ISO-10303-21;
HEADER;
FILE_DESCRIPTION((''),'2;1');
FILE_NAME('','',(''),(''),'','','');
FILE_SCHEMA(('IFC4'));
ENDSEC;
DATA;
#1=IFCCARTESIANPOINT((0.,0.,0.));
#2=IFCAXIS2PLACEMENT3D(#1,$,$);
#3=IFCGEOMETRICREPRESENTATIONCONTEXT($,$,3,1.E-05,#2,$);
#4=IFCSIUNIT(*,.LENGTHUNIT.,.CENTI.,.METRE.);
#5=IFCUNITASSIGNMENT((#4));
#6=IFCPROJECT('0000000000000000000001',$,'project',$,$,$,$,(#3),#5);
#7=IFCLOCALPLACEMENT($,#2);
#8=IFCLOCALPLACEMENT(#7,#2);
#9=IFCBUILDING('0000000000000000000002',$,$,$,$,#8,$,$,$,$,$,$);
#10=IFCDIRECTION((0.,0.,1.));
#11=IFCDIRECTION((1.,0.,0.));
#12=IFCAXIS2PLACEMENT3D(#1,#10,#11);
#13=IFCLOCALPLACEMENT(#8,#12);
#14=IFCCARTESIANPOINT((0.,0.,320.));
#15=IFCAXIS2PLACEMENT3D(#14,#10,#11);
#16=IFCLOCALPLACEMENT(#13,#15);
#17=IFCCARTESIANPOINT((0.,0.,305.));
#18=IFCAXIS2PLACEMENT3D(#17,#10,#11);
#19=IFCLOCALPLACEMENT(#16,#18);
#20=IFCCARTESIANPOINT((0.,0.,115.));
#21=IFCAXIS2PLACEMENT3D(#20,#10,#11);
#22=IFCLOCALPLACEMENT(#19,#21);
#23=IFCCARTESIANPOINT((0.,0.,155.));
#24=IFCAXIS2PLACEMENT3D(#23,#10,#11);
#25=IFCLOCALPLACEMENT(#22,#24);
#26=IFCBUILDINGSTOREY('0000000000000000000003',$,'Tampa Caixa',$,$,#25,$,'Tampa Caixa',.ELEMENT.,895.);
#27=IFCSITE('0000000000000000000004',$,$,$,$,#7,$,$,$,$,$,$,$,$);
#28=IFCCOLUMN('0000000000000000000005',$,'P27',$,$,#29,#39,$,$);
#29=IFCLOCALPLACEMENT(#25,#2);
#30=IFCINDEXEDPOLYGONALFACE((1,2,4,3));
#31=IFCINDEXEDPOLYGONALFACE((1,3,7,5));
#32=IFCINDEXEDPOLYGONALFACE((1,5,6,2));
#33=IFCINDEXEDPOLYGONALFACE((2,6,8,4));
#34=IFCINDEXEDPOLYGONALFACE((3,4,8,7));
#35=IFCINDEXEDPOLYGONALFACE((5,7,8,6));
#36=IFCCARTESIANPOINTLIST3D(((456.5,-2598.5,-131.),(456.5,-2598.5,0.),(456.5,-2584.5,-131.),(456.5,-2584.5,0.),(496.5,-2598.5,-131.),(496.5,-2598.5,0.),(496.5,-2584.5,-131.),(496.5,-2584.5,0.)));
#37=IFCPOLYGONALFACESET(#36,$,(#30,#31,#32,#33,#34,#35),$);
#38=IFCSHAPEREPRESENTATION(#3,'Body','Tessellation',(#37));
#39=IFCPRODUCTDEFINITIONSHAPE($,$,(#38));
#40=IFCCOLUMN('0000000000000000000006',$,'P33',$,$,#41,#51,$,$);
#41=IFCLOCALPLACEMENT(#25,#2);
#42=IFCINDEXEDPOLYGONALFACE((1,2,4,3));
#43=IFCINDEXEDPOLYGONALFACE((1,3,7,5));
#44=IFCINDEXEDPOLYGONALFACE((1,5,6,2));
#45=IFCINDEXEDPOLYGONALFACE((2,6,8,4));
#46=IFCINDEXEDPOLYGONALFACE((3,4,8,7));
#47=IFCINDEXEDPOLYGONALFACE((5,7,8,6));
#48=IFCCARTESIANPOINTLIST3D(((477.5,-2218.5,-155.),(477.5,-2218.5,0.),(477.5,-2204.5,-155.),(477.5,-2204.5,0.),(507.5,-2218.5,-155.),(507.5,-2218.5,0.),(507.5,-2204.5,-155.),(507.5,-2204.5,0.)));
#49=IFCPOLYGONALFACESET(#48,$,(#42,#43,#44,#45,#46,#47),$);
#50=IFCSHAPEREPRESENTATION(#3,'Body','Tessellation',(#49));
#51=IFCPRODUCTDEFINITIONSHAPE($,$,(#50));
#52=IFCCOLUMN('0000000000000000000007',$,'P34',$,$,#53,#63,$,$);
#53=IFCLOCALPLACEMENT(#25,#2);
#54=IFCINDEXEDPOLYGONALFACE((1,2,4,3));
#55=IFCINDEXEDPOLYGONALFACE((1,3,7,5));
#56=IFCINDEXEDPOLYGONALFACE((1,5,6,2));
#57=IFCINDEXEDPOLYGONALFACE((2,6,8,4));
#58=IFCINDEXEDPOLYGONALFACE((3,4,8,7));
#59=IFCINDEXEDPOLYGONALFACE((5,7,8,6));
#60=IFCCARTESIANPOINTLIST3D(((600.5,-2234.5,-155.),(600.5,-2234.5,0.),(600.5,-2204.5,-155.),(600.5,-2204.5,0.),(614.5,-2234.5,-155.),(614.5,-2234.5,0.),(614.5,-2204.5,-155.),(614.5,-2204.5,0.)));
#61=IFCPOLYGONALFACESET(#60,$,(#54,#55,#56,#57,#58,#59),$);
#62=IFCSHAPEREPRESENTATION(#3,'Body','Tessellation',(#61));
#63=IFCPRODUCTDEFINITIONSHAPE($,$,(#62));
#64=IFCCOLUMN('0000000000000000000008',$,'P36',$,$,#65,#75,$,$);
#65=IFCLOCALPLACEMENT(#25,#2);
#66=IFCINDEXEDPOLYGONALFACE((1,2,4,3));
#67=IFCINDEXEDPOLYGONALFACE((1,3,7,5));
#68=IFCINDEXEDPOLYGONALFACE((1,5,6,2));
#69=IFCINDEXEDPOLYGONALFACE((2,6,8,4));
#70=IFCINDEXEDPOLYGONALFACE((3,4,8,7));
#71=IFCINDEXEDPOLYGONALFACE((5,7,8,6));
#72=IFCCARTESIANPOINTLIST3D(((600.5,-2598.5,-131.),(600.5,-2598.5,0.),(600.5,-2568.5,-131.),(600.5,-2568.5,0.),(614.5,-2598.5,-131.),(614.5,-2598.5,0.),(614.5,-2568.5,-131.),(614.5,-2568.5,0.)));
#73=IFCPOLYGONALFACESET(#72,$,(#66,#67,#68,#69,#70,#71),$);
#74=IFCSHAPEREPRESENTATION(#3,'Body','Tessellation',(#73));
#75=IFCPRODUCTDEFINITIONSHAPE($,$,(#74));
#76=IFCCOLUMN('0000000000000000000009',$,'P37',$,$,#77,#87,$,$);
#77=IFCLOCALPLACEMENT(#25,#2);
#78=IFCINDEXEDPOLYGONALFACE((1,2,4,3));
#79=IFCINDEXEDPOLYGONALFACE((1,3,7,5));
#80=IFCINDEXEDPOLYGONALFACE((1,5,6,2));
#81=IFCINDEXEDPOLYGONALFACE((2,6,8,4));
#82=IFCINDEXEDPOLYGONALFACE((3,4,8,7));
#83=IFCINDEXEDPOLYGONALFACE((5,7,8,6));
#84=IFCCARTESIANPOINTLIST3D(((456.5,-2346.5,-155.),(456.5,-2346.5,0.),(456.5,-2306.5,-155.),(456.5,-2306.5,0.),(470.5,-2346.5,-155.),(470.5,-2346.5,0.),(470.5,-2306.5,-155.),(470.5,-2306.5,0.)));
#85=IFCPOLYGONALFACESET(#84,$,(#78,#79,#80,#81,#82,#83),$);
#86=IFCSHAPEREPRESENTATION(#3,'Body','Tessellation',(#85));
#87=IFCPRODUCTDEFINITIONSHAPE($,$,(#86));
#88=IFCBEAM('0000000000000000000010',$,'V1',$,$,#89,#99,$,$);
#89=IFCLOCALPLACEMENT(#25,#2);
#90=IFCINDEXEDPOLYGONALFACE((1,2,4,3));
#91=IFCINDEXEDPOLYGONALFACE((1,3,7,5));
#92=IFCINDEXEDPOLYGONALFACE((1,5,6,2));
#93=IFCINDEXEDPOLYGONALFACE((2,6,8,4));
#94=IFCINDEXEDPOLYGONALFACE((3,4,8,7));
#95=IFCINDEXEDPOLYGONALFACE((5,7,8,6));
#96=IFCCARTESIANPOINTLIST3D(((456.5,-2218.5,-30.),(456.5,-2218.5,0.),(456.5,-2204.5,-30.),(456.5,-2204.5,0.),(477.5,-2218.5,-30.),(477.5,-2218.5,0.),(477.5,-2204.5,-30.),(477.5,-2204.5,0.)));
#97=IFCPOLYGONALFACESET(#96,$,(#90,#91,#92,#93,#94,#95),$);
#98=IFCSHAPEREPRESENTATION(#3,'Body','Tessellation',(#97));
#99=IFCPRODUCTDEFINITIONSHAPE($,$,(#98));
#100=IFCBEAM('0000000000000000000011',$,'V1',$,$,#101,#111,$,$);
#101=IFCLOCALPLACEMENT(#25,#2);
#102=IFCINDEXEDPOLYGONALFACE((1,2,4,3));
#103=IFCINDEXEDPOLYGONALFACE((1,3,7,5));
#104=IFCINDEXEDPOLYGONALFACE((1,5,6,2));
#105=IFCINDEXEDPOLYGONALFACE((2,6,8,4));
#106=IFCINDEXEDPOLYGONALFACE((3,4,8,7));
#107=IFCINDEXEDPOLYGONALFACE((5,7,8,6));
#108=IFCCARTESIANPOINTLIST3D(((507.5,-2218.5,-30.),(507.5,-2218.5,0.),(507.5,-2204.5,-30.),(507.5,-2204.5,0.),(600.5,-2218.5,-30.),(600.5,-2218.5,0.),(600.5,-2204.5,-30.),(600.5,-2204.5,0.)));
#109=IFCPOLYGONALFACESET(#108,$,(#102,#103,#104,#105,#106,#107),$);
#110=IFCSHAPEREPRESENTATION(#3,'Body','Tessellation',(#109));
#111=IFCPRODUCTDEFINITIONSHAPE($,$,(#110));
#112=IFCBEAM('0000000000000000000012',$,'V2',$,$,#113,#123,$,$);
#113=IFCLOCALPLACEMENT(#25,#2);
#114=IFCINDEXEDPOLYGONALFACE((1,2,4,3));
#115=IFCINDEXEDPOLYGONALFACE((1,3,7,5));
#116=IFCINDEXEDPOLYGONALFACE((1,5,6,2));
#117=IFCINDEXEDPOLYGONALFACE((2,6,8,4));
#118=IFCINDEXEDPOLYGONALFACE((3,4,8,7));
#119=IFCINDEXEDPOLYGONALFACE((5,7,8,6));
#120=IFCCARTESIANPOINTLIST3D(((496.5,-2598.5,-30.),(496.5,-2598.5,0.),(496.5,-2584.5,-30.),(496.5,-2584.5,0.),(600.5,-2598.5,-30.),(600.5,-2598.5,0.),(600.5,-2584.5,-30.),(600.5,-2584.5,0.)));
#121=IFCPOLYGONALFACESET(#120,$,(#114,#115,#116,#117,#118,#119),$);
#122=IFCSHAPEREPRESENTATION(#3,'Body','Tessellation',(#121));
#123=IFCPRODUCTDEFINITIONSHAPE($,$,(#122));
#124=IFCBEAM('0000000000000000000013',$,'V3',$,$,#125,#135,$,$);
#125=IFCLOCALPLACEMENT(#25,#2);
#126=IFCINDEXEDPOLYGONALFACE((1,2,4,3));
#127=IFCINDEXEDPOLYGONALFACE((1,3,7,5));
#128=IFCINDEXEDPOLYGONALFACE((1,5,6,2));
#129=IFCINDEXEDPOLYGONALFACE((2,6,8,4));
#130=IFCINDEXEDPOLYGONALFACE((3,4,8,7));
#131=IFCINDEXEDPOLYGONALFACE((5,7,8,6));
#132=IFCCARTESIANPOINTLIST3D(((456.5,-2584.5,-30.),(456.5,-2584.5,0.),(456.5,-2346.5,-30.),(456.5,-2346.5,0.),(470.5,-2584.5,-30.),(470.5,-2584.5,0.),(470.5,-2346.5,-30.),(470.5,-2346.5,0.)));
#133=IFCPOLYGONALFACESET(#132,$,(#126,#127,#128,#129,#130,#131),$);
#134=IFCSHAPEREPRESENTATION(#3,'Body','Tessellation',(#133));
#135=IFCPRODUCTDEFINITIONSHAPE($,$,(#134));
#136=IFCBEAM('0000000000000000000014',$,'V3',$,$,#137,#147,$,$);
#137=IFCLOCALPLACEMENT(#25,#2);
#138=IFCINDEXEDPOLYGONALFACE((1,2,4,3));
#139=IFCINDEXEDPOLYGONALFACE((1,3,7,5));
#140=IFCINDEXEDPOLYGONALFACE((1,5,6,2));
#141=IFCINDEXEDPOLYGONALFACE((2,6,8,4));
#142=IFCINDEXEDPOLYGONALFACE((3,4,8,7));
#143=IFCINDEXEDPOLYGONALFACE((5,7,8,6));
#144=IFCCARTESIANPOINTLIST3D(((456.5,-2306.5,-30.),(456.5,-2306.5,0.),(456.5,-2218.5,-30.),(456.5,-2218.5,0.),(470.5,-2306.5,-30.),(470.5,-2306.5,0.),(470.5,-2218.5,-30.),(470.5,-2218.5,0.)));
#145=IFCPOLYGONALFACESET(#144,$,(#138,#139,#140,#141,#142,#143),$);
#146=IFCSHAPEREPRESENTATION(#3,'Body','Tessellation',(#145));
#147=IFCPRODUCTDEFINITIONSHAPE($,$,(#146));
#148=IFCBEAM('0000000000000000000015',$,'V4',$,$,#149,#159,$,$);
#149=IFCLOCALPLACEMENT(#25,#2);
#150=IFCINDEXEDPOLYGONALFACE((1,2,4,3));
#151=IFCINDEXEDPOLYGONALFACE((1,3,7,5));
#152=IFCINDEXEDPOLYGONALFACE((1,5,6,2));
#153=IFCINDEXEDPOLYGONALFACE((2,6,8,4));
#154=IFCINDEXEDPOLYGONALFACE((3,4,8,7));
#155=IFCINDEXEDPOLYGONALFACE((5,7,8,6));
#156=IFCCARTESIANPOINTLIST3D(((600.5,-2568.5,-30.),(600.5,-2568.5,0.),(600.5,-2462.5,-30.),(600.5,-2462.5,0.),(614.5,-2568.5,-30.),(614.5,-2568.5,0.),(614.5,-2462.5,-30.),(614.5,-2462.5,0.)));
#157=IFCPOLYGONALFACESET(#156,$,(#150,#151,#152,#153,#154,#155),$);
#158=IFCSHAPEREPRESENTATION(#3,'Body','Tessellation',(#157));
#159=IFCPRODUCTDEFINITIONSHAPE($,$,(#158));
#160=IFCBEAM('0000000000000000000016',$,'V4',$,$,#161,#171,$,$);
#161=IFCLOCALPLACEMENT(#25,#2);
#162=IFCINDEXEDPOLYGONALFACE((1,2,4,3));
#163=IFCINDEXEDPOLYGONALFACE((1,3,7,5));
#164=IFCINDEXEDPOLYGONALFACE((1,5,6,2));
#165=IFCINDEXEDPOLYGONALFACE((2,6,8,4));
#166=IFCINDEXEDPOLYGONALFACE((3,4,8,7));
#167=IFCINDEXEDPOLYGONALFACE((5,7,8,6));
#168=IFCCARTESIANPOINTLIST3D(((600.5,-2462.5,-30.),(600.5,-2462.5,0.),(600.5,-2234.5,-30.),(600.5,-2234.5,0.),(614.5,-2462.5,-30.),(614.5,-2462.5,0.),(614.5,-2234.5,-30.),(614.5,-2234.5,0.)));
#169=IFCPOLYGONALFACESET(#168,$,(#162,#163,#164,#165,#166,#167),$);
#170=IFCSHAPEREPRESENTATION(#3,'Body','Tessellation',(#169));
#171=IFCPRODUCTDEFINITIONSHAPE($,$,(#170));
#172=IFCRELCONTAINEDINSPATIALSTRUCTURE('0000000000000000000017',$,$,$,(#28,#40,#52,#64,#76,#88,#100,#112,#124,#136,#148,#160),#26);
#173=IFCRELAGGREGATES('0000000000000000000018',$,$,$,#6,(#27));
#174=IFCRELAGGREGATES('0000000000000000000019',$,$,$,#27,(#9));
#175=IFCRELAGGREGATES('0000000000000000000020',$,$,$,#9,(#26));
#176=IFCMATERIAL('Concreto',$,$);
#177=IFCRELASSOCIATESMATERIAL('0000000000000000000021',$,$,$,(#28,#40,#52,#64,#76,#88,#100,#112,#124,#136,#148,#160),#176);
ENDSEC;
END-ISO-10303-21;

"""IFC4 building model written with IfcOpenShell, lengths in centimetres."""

from ifc_helpers import new_model, si_unit, frame, origin, origin_with_axes, place, context, project, spatial, polyline, outline, extrude, material, element, save


model = new_model("IFC4")

# Units and contexts
context_of_model = context(None, 3, precision=1e-05, world=origin())
ifc_project = project(units=[si_unit("LENGTHUNIT", "METRE", prefix="CENTI")], contexts=[context_of_model])

# Site, building, storey
site_placement = place(None, origin())
site = spatial("IfcSite", under=ifc_project, at=site_placement)
building_placement = place(site_placement, origin())
building = spatial("IfcBuilding", under=site, at=building_placement)
placement_1 = place(building_placement, origin_with_axes())
placement_2 = place(placement_1, frame((0.0, 0.0, 320.0), z_axis=(0.0, 0.0, 1.0), x_axis=(1.0, 0.0, 0.0)))
placement_3 = place(placement_2, frame((0.0, 0.0, 305.0), z_axis=(0.0, 0.0, 1.0), x_axis=(1.0, 0.0, 0.0)))
placement_4 = place(placement_3, frame((0.0, 0.0, 115.0), z_axis=(0.0, 0.0, 1.0), x_axis=(1.0, 0.0, 0.0)))
storey_placement = place(placement_4, frame((0.0, 0.0, 155.0), z_axis=(0.0, 0.0, 1.0), x_axis=(1.0, 0.0, 0.0)))
storey = spatial("IfcBuildingStorey", under=building, at=storey_placement, Name="Tampa Caixa", LongName="Tampa Caixa", CompositionType="ELEMENT", Elevation=895.0)

# Columns
ifc_material = material(Name="Concreto")
column_1_placement = place(storey_placement, frame((476.5, -2591.5, 0.0), z_axis=(0.0, 0.0, 1.0), x_axis=(1.0, 0.0, 0.0)))
element("IfcColumn", 1, at=column_1_placement, inside=storey, material=ifc_material, Name="P27", context=context_of_model, shape_type="SolidModel", body=[
    extrude(outline(polyline([(20.0, -7.0), (20.0, 7.0), (-20.0, 7.0), (-20.0, -7.0), (20.0, -7.0)])), origin_with_axes(), (0.0, 0.0, -1.0), 131.0),
])
column_2_placement = place(storey_placement, frame((492.5, -2211.5, 0.0), z_axis=(0.0, 0.0, 1.0), x_axis=(1.0, 0.0, 0.0)))
element("IfcColumn", 2, at=column_2_placement, inside=storey, material=ifc_material, Name="P33", context=context_of_model, shape_type="SolidModel", body=[
    extrude(outline(polyline([(15.0, -7.0), (15.0, 7.0), (-15.0, 7.0), (-15.0, -7.0), (15.0, -7.0)])), origin_with_axes(), (0.0, 0.0, -1.0), 155.0),
])
column_3_placement = place(storey_placement, frame((607.5, -2219.5, 0.0), z_axis=(0.0, 0.0, 1.0), x_axis=(1.0, 0.0, 0.0)))
element("IfcColumn", 3, at=column_3_placement, inside=storey, material=ifc_material, Name="P34", context=context_of_model, shape_type="SolidModel", body=[
    extrude(outline(polyline([(7.0, 15.0), (-7.0, 15.0), (-7.0, -15.0), (7.0, -15.0), (7.0, 15.0)])), origin_with_axes(), (0.0, 0.0, -1.0), 155.0),
])
column_4_placement = place(storey_placement, frame((607.5, -2583.5, 0.0), z_axis=(0.0, 0.0, 1.0), x_axis=(1.0, 0.0, 0.0)))
element("IfcColumn", 4, at=column_4_placement, inside=storey, material=ifc_material, Name="P36", context=context_of_model, shape_type="SolidModel", body=[
    extrude(outline(polyline([(7.0, 15.0), (-7.0, 15.0), (-7.0, -15.0), (7.0, -15.0), (7.0, 15.0)])), origin_with_axes(), (0.0, 0.0, -1.0), 131.0),
])
column_5_placement = place(storey_placement, frame((463.5, -2326.5, 0.0), z_axis=(0.0, 0.0, 1.0), x_axis=(1.0, 0.0, 0.0)))
element("IfcColumn", 5, at=column_5_placement, inside=storey, material=ifc_material, Name="P37", context=context_of_model, shape_type="SolidModel", body=[
    extrude(outline(polyline([(-7.0, -20.0), (7.0, -20.0), (7.0, 20.0), (-7.0, 20.0), (-7.0, -20.0)])), origin_with_axes(), (0.0, 0.0, -1.0), 155.0),
])

# Beams
beam_1_placement = place(storey_placement, frame((467.0, -2211.5, 0.0), z_axis=(0.0, 0.0, 1.0), x_axis=(1.0, 0.0, 0.0)))
element("IfcBeam", 6, at=beam_1_placement, inside=storey, material=ifc_material, Name="V1", context=context_of_model, shape_type="SolidModel", body=[
    extrude(outline(polyline([(-7.0, -15.0), (7.0, -15.0), (7.0, 15.0), (-7.0, 15.0), (-7.0, -15.0)])), frame((-10.5, 0.0, -15.0), z_axis=(1.0, 0.0, 0.0), x_axis=(0.0, -1.0, 0.0)), (0.0, 0.0, 1.0), 21.0),
])
beam_2_placement = place(storey_placement, frame((554.0, -2211.5, 0.0), z_axis=(0.0, 0.0, 1.0), x_axis=(1.0, 0.0, 0.0)))
element("IfcBeam", 7, at=beam_2_placement, inside=storey, material=ifc_material, Name="V1", context=context_of_model, shape_type="SolidModel", body=[
    extrude(outline(polyline([(-7.0, -15.0), (7.0, -15.0), (7.0, 15.0), (-7.0, 15.0), (-7.0, -15.0)])), frame((-46.5, 0.0, -15.0), z_axis=(1.0, 0.0, 0.0), x_axis=(0.0, -1.0, 0.0)), (0.0, 0.0, 1.0), 93.0),
])
beam_3_placement = place(storey_placement, frame((548.5, -2591.5, 0.0), z_axis=(0.0, 0.0, 1.0), x_axis=(1.0, 0.0, 0.0)))
element("IfcBeam", 8, at=beam_3_placement, inside=storey, material=ifc_material, Name="V2", context=context_of_model, shape_type="SolidModel", body=[
    extrude(outline(polyline([(-7.0, -15.0), (7.0, -15.0), (7.0, 15.0), (-7.0, 15.0), (-7.0, -15.0)])), frame((-52.0, 0.0, -15.0), z_axis=(1.0, 0.0, 0.0), x_axis=(0.0, -1.0, 0.0)), (0.0, 0.0, 1.0), 104.0),
])
beam_4_placement = place(storey_placement, frame((463.5, -2465.5, 0.0), z_axis=(0.0, 0.0, 1.0), x_axis=(1.0, 0.0, 0.0)))
element("IfcBeam", 9, at=beam_4_placement, inside=storey, material=ifc_material, Name="V3", context=context_of_model, shape_type="SolidModel", body=[
    extrude(outline(polyline([(-7.0, -15.0), (7.0, -15.0), (7.0, 15.0), (-7.0, 15.0), (-7.0, -15.0)])), frame((0.0, -119.0, -15.0), z_axis=(0.0, 1.0, 0.0), x_axis=(1.0, 0.0, 0.0)), (0.0, 0.0, 1.0), 238.0),
])
beam_5_placement = place(storey_placement, frame((463.5, -2262.5, 0.0), z_axis=(0.0, 0.0, 1.0), x_axis=(1.0, 0.0, 0.0)))
element("IfcBeam", 10, at=beam_5_placement, inside=storey, material=ifc_material, Name="V3", context=context_of_model, shape_type="SolidModel", body=[
    extrude(outline(polyline([(-7.0, -15.0), (7.0, -15.0), (7.0, 15.0), (-7.0, 15.0), (-7.0, -15.0)])), frame((0.0, -44.0, -15.0), z_axis=(0.0, 1.0, 0.0), x_axis=(1.0, 0.0, 0.0)), (0.0, 0.0, 1.0), 88.0),
])
beam_6_placement = place(storey_placement, frame((607.5, -2515.5, 0.0), z_axis=(0.0, 0.0, 1.0), x_axis=(1.0, 0.0, 0.0)))
element("IfcBeam", 11, at=beam_6_placement, inside=storey, material=ifc_material, Name="V4", context=context_of_model, shape_type="SolidModel", body=[
    extrude(outline(polyline([(-7.0, -15.0), (7.0, -15.0), (7.0, 15.0), (-7.0, 15.0), (-7.0, -15.0)])), frame((0.0, -53.0, -15.0), z_axis=(0.0, 1.0, 0.0), x_axis=(1.0, 0.0, 0.0)), (0.0, 0.0, 1.0), 106.0),
])
beam_7_placement = place(storey_placement, frame((607.5, -2348.5, 0.0), z_axis=(0.0, 0.0, 1.0), x_axis=(1.0, 0.0, 0.0)))
element("IfcBeam", 12, at=beam_7_placement, inside=storey, material=ifc_material, Name="V4", context=context_of_model, shape_type="SolidModel", body=[
    extrude(outline(polyline([(-7.0, -15.0), (7.0, -15.0), (7.0, 15.0), (-7.0, 15.0), (-7.0, -15.0)])), frame((0.0, -114.0, -15.0), z_axis=(0.0, 1.0, 0.0), x_axis=(1.0, 0.0, 0.0)), (0.0, 0.0, 1.0), 228.0),
])

save(model, "model.ifc")
